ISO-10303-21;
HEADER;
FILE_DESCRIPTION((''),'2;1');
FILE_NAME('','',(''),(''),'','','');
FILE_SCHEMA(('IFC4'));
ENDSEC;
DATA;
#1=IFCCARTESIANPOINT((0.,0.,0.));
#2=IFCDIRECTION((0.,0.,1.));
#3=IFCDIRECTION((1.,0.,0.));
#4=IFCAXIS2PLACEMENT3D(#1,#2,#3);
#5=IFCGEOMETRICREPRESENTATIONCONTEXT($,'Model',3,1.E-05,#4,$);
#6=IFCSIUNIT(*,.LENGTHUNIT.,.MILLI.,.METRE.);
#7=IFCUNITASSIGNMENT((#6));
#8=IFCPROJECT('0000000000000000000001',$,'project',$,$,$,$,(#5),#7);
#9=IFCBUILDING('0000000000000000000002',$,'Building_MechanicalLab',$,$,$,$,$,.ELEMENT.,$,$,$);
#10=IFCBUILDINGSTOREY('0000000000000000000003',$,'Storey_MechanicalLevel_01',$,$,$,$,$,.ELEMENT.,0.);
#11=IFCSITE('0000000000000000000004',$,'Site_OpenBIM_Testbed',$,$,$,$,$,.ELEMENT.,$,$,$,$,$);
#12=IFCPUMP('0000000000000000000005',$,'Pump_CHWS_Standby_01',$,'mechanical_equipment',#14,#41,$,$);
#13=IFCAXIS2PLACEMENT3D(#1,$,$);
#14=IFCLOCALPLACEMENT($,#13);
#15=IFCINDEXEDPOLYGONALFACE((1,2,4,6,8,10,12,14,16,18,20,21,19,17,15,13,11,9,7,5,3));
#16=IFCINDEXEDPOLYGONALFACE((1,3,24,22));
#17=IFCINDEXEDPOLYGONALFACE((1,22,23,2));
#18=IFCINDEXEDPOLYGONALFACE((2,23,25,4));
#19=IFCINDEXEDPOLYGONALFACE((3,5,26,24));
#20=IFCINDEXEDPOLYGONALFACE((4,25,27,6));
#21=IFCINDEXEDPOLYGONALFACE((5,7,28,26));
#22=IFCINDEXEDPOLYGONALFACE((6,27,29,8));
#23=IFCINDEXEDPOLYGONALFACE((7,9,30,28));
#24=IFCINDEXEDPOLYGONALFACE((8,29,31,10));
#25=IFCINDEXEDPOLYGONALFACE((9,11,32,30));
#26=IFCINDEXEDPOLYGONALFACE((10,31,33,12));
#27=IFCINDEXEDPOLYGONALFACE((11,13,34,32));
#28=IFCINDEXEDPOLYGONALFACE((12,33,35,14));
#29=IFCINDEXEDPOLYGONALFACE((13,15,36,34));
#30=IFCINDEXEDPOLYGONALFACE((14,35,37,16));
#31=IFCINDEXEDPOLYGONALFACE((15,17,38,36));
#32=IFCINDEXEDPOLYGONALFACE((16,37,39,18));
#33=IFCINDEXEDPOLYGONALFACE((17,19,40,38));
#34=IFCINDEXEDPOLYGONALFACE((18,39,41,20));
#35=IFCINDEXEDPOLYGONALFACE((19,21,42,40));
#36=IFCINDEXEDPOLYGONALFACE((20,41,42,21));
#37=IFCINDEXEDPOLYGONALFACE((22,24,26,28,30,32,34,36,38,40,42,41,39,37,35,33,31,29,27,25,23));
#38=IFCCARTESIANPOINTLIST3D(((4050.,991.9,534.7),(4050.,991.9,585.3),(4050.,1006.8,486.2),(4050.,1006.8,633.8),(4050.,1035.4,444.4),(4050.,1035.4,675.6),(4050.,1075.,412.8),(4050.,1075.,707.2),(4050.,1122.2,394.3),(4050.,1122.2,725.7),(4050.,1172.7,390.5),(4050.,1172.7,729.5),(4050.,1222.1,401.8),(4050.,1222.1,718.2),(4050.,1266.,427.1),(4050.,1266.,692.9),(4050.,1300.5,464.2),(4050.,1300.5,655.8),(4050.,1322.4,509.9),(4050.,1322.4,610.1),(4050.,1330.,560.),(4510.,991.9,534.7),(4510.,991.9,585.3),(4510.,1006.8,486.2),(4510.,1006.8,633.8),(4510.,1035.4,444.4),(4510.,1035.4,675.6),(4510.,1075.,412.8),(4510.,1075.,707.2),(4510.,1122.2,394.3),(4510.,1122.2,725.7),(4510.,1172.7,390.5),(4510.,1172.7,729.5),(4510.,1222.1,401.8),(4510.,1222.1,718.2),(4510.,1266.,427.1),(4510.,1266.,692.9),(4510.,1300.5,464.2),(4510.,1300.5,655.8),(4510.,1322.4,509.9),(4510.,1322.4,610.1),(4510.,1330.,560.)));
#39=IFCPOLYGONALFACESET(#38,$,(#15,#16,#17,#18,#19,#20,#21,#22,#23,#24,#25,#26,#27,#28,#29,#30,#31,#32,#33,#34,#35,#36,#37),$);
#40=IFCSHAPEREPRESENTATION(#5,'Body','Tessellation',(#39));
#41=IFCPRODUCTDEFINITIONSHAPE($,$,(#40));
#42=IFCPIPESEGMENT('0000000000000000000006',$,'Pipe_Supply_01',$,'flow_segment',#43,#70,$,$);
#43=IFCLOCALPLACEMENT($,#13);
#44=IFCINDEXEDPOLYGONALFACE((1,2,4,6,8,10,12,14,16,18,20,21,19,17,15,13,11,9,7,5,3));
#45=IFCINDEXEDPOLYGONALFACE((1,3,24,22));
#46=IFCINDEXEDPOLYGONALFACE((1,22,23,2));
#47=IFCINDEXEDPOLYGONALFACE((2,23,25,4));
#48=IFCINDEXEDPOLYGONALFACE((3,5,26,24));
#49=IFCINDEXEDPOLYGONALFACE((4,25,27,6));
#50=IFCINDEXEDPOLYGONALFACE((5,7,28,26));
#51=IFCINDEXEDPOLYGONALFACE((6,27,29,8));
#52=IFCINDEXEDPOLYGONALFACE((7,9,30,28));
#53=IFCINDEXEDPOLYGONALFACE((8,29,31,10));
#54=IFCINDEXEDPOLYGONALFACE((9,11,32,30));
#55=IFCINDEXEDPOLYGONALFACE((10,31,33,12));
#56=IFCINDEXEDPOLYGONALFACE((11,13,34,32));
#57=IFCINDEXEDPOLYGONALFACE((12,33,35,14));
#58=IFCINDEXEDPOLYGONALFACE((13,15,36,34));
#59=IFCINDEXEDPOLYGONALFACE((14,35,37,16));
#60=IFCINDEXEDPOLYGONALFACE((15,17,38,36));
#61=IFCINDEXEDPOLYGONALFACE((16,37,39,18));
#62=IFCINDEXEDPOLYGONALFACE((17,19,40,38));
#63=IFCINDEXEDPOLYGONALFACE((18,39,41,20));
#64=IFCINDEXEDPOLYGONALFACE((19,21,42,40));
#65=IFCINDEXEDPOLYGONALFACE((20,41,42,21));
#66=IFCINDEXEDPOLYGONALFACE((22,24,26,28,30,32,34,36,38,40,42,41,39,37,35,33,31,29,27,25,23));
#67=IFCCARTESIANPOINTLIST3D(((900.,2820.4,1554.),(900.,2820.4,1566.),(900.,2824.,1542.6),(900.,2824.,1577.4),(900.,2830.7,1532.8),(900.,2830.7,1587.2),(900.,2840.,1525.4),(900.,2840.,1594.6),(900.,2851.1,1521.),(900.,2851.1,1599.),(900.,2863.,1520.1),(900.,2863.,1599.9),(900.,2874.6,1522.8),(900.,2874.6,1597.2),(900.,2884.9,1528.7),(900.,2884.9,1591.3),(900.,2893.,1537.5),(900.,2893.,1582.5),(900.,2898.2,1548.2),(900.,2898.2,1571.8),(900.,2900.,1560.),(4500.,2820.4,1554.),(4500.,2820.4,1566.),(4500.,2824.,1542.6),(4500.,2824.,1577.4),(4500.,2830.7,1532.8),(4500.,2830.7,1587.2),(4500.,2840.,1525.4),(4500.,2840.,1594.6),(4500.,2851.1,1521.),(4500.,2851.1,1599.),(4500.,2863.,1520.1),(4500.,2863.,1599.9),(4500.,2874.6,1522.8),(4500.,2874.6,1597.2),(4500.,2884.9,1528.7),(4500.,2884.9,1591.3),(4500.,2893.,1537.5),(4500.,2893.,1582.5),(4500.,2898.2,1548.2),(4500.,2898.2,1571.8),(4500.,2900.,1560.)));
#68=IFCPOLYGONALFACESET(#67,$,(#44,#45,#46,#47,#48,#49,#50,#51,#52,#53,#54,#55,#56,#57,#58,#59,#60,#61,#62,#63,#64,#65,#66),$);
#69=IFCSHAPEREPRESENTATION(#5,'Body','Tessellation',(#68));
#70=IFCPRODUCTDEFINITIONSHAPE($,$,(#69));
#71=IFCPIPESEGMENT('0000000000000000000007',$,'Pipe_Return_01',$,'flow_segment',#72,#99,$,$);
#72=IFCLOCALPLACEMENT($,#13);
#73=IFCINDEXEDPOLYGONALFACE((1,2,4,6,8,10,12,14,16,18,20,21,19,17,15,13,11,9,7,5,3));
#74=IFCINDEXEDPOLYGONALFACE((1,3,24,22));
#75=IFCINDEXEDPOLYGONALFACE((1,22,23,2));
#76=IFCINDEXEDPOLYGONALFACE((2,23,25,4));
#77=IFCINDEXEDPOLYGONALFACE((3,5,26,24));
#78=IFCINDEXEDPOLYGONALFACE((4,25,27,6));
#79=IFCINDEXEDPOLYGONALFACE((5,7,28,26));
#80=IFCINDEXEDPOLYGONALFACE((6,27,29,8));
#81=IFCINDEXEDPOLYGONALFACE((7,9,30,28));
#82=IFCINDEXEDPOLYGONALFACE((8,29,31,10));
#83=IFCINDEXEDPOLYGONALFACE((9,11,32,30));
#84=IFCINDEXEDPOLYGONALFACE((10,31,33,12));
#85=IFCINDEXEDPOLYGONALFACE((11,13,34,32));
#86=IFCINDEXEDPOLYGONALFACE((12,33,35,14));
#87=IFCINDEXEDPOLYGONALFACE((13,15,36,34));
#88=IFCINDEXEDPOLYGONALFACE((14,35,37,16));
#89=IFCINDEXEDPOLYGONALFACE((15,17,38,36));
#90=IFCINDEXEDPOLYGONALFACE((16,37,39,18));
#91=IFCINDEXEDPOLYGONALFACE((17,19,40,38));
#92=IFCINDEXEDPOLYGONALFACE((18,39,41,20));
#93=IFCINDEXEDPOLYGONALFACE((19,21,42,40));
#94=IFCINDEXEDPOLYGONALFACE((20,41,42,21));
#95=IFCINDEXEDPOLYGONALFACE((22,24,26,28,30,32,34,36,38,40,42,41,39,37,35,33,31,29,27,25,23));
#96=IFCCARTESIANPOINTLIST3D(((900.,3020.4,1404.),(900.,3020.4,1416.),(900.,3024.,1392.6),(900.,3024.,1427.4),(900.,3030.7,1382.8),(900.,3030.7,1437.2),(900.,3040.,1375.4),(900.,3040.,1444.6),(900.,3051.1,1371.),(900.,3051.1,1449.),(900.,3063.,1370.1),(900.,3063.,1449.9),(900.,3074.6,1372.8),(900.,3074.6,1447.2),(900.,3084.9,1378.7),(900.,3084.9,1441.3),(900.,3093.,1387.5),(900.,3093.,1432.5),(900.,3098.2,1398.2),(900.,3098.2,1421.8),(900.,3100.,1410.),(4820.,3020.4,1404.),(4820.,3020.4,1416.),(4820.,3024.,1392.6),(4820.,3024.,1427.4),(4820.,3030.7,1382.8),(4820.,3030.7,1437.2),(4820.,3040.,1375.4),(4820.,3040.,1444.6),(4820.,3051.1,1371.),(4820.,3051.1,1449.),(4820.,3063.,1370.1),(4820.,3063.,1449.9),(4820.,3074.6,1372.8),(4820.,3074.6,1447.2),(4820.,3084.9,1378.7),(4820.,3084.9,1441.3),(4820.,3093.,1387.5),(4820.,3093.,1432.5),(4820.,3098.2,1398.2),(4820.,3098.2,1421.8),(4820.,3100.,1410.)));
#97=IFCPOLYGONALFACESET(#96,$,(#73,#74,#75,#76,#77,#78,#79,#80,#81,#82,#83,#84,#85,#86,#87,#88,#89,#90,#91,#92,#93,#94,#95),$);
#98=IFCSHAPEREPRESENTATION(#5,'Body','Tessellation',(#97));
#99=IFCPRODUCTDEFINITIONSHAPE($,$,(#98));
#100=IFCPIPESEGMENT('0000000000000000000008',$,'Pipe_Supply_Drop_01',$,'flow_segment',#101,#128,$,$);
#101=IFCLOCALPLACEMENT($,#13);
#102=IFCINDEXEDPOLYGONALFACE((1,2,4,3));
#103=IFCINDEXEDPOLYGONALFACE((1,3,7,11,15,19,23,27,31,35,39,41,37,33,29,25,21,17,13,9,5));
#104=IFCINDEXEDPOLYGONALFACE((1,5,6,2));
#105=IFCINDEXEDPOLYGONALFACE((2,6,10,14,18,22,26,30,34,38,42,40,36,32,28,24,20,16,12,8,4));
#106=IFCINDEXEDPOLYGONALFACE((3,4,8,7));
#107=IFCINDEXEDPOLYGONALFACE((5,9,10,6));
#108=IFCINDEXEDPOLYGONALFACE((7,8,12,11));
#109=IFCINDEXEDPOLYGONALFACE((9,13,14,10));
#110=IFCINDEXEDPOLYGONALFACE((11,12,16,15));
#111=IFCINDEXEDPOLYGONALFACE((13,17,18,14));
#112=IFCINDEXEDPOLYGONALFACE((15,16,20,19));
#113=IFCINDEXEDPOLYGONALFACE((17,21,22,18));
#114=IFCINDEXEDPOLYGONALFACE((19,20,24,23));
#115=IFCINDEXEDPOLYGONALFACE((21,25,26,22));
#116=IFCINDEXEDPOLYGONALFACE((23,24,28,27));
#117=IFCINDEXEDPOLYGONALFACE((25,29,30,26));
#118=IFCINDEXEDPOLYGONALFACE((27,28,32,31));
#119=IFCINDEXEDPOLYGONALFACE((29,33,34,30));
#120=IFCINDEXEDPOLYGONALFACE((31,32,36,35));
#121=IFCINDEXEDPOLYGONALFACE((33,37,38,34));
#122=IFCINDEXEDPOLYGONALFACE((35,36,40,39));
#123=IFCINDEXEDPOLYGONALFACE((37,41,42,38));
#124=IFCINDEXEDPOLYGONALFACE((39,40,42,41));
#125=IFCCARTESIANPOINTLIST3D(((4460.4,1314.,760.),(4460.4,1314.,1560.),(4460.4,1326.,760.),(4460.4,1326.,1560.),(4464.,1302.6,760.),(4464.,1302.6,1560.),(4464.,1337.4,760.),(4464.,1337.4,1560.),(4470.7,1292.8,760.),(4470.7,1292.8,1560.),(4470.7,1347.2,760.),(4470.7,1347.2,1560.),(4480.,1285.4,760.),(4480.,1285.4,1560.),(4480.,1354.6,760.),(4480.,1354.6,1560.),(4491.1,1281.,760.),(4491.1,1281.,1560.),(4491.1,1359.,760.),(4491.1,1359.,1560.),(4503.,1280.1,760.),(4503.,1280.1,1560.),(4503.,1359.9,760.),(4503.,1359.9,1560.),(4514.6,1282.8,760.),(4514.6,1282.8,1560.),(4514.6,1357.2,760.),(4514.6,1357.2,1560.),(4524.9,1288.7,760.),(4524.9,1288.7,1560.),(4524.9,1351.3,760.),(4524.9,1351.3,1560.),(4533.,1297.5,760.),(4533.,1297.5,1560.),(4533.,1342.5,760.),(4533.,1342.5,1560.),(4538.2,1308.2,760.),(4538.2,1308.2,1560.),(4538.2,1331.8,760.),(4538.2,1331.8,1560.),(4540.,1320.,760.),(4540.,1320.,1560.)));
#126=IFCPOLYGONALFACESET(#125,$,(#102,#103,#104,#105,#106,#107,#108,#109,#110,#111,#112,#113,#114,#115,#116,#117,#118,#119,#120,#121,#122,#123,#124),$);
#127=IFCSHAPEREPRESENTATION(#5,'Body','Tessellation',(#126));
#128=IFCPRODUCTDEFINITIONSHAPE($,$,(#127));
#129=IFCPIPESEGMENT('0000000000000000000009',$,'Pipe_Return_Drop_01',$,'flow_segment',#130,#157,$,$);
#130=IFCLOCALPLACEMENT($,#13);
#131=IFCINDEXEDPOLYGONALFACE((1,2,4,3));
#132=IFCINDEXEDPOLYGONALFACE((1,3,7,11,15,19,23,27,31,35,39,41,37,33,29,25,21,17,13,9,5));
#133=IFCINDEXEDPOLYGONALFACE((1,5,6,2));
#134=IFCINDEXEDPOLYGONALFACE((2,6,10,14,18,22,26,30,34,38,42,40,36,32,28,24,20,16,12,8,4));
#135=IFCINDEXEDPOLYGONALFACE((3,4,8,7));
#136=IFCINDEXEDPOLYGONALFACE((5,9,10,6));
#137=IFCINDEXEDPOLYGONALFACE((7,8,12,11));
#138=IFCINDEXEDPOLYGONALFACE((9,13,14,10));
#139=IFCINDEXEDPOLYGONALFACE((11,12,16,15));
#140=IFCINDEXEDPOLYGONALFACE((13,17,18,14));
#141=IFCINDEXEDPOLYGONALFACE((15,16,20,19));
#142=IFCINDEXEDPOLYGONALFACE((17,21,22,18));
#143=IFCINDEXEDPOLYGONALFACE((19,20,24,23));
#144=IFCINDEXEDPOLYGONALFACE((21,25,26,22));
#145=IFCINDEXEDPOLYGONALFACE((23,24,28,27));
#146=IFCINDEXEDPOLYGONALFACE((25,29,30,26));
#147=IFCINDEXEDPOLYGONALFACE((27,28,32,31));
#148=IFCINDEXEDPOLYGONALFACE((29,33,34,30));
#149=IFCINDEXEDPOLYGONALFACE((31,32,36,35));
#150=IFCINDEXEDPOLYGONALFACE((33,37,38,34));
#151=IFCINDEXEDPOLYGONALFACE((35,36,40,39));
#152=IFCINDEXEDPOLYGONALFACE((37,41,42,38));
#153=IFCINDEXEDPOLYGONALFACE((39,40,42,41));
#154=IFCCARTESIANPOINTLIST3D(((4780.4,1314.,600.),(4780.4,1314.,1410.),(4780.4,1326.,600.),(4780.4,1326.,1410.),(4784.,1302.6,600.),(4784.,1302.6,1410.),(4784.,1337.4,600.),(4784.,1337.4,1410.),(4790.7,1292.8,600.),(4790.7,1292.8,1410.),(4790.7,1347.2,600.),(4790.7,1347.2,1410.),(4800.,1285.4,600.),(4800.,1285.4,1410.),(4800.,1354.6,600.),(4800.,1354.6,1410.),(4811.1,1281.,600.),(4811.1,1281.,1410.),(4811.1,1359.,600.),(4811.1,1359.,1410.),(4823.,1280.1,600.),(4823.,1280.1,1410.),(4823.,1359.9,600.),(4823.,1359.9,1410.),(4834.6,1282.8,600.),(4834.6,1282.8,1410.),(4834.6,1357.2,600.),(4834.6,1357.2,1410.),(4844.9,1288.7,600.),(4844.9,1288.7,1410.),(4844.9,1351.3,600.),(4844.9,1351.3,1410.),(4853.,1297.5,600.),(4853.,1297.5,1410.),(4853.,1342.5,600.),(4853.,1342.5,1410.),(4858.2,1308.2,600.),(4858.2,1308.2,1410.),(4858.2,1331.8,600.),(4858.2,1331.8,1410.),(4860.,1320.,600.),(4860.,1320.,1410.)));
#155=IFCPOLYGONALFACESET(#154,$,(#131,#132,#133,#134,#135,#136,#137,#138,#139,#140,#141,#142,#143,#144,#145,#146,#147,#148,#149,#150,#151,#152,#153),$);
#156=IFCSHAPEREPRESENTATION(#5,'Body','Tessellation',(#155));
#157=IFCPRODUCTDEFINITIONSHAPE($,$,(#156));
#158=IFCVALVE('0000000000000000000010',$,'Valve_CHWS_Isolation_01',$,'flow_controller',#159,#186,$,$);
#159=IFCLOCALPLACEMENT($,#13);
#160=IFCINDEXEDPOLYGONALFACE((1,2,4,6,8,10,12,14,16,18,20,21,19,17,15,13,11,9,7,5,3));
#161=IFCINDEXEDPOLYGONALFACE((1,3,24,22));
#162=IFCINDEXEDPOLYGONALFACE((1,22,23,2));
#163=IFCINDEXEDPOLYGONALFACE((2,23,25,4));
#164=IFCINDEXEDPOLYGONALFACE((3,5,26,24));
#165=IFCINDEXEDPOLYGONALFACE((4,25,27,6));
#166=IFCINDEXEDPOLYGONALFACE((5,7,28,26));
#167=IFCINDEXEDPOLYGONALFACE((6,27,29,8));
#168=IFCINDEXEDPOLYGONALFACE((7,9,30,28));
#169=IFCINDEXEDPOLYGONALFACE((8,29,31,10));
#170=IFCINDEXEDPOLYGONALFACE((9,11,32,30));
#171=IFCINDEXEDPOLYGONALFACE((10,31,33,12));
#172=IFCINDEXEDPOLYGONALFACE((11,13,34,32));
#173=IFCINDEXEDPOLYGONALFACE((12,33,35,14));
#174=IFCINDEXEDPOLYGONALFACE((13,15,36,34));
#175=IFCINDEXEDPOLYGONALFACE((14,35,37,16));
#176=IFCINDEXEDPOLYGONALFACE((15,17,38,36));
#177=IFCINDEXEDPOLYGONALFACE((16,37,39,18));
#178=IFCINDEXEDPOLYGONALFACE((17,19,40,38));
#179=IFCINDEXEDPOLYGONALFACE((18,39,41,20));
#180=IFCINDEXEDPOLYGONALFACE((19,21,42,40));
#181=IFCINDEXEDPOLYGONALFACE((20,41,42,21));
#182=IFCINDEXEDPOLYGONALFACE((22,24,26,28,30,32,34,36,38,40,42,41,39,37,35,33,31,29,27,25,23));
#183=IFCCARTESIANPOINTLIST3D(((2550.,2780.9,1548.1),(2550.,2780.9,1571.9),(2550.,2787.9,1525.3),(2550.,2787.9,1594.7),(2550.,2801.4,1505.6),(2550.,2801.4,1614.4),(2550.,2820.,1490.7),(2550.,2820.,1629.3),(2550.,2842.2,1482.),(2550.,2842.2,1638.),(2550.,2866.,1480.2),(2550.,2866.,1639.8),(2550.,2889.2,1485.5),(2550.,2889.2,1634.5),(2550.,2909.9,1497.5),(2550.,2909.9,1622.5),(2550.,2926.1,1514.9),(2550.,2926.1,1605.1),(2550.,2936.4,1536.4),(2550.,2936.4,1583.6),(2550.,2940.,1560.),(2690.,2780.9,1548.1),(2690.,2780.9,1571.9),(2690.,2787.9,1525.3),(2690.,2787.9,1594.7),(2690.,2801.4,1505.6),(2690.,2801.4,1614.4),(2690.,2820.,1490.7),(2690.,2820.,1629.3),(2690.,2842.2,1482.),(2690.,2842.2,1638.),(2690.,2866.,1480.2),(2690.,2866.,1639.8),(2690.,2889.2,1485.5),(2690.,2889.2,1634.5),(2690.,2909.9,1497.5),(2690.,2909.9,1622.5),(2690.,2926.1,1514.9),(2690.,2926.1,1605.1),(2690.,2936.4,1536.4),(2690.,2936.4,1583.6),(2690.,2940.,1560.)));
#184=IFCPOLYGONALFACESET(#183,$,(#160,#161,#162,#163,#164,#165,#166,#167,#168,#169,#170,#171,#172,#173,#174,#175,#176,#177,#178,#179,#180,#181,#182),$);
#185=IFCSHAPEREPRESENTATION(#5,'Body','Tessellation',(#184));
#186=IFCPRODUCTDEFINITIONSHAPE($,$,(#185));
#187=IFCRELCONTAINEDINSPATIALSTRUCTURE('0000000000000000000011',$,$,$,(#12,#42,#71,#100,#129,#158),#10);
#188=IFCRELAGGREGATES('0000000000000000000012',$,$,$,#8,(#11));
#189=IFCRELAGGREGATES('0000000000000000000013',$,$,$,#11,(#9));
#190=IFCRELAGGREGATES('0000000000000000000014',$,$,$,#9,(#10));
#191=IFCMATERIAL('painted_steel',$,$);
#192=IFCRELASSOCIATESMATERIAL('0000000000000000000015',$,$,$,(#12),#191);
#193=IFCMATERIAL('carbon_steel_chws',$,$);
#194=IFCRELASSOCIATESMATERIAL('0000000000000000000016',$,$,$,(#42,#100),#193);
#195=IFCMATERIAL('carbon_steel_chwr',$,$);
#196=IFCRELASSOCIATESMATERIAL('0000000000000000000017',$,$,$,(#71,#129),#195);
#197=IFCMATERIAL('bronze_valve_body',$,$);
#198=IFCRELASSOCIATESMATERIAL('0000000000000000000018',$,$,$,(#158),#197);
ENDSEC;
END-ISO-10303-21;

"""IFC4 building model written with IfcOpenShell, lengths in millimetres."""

from ifc_helpers import new_model, si_unit, frame, origin_with_axes, place, context, project, spatial, circle, extrude, material, element, save


model = new_model("IFC4")

# Units and contexts
model_context = context("Model", 3, precision=1e-05, world=origin_with_axes())
ifc_project = project(units=[si_unit("LENGTHUNIT", "METRE", prefix="MILLI")], contexts=[model_context])

# Site, building, storey
site = spatial("IfcSite", under=ifc_project, Name="Site_OpenBIM_Testbed", CompositionType="ELEMENT")
building = spatial("IfcBuilding", under=site, Name="Building_MechanicalLab", CompositionType="ELEMENT")
storey = spatial("IfcBuildingStorey", under=building, Name="Storey_MechanicalLevel_01", CompositionType="ELEMENT", Elevation=0.0)

# Shared definitions
ifc_material_1 = material(Name="painted_steel")

# Pump
for number, where, z_axis, x_axis, name in (
    (1, (4050.0, 1160.0, 560.0), (0.0, 0.0, 1.0), (1.0, 0.0, 0.0), "Pump_CHWS_Standby_01"),
):
    element("IfcPump", number, at=place(None, frame(where, z_axis=z_axis, x_axis=x_axis)), inside=storey, material=ifc_material_1, Name=name, ObjectType="mechanical_equipment", context=model_context, shape_type="SweptSolid", body=[
        extrude(circle(Radius=170.0), frame((0.0, 0.0, 0.0), z_axis=(1.0, 0.0, 0.0), x_axis=(0.0, 1.0, 0.0)), (0.0, 0.0, 1.0), 460.0),
    ])

# Pipe segments
ifc_material_2 = material(Name="carbon_steel_chws")
pipe_segment_1_placement = place(None, frame((900.0, 2860.0, 1560.0), z_axis=(0.0, 0.0, 1.0), x_axis=(1.0, 0.0, 0.0)))
element("IfcPipeSegment", 2, at=pipe_segment_1_placement, inside=storey, material=ifc_material_2, Name="Pipe_Supply_01", ObjectType="flow_segment", context=model_context, shape_type="SweptSolid", body=[
    extrude(circle(Radius=40.0), frame((0.0, 0.0, 0.0), z_axis=(1.0, 0.0, 0.0), x_axis=(0.0, 1.0, 0.0)), (0.0, 0.0, 1.0), 3600.0),
])
ifc_material_3 = material(Name="carbon_steel_chwr")
pipe_segment_2_placement = place(None, frame((900.0, 3060.0, 1410.0), z_axis=(0.0, 0.0, 1.0), x_axis=(1.0, 0.0, 0.0)))
element("IfcPipeSegment", 3, at=pipe_segment_2_placement, inside=storey, material=ifc_material_3, Name="Pipe_Return_01", ObjectType="flow_segment", context=model_context, shape_type="SweptSolid", body=[
    extrude(circle(Radius=40.0), frame((0.0, 0.0, 0.0), z_axis=(1.0, 0.0, 0.0), x_axis=(0.0, 1.0, 0.0)), (0.0, 0.0, 1.0), 3920.0),
])
pipe_segment_3_placement = place(None, frame((4500.0, 1320.0, 760.0), z_axis=(0.0, 0.0, 1.0), x_axis=(1.0, 0.0, 0.0)))
element("IfcPipeSegment", 4, at=pipe_segment_3_placement, inside=storey, material=ifc_material_2, Name="Pipe_Supply_Drop_01", ObjectType="flow_segment", context=model_context, shape_type="SweptSolid", body=[
    extrude(circle(Radius=40.0), origin_with_axes(), (0.0, 0.0, 1.0), 800.0),
])
pipe_segment_4_placement = place(None, frame((4820.0, 1320.0, 600.0), z_axis=(0.0, 0.0, 1.0), x_axis=(1.0, 0.0, 0.0)))
element("IfcPipeSegment", 5, at=pipe_segment_4_placement, inside=storey, material=ifc_material_3, Name="Pipe_Return_Drop_01", ObjectType="flow_segment", context=model_context, shape_type="SweptSolid", body=[
    extrude(circle(Radius=40.0), origin_with_axes(), (0.0, 0.0, 1.0), 810.0),
])

# Valve
ifc_material_4 = material(Name="bronze_valve_body")
for number, where, z_axis, x_axis, name in (
    (6, (2550.0, 2860.0, 1560.0), (0.0, 0.0, 1.0), (1.0, 0.0, 0.0), "Valve_CHWS_Isolation_01"),
):
    element("IfcValve", number, at=place(None, frame(where, z_axis=z_axis, x_axis=x_axis)), inside=storey, material=ifc_material_4, Name=name, ObjectType="flow_controller", context=model_context, shape_type="SweptSolid", body=[
        extrude(circle(Radius=80.0), frame((0.0, 0.0, 0.0), z_axis=(1.0, 0.0, 0.0), x_axis=(0.0, 1.0, 0.0)), (0.0, 0.0, 1.0), 140.0),
    ])

save(model, "model.ifc")
